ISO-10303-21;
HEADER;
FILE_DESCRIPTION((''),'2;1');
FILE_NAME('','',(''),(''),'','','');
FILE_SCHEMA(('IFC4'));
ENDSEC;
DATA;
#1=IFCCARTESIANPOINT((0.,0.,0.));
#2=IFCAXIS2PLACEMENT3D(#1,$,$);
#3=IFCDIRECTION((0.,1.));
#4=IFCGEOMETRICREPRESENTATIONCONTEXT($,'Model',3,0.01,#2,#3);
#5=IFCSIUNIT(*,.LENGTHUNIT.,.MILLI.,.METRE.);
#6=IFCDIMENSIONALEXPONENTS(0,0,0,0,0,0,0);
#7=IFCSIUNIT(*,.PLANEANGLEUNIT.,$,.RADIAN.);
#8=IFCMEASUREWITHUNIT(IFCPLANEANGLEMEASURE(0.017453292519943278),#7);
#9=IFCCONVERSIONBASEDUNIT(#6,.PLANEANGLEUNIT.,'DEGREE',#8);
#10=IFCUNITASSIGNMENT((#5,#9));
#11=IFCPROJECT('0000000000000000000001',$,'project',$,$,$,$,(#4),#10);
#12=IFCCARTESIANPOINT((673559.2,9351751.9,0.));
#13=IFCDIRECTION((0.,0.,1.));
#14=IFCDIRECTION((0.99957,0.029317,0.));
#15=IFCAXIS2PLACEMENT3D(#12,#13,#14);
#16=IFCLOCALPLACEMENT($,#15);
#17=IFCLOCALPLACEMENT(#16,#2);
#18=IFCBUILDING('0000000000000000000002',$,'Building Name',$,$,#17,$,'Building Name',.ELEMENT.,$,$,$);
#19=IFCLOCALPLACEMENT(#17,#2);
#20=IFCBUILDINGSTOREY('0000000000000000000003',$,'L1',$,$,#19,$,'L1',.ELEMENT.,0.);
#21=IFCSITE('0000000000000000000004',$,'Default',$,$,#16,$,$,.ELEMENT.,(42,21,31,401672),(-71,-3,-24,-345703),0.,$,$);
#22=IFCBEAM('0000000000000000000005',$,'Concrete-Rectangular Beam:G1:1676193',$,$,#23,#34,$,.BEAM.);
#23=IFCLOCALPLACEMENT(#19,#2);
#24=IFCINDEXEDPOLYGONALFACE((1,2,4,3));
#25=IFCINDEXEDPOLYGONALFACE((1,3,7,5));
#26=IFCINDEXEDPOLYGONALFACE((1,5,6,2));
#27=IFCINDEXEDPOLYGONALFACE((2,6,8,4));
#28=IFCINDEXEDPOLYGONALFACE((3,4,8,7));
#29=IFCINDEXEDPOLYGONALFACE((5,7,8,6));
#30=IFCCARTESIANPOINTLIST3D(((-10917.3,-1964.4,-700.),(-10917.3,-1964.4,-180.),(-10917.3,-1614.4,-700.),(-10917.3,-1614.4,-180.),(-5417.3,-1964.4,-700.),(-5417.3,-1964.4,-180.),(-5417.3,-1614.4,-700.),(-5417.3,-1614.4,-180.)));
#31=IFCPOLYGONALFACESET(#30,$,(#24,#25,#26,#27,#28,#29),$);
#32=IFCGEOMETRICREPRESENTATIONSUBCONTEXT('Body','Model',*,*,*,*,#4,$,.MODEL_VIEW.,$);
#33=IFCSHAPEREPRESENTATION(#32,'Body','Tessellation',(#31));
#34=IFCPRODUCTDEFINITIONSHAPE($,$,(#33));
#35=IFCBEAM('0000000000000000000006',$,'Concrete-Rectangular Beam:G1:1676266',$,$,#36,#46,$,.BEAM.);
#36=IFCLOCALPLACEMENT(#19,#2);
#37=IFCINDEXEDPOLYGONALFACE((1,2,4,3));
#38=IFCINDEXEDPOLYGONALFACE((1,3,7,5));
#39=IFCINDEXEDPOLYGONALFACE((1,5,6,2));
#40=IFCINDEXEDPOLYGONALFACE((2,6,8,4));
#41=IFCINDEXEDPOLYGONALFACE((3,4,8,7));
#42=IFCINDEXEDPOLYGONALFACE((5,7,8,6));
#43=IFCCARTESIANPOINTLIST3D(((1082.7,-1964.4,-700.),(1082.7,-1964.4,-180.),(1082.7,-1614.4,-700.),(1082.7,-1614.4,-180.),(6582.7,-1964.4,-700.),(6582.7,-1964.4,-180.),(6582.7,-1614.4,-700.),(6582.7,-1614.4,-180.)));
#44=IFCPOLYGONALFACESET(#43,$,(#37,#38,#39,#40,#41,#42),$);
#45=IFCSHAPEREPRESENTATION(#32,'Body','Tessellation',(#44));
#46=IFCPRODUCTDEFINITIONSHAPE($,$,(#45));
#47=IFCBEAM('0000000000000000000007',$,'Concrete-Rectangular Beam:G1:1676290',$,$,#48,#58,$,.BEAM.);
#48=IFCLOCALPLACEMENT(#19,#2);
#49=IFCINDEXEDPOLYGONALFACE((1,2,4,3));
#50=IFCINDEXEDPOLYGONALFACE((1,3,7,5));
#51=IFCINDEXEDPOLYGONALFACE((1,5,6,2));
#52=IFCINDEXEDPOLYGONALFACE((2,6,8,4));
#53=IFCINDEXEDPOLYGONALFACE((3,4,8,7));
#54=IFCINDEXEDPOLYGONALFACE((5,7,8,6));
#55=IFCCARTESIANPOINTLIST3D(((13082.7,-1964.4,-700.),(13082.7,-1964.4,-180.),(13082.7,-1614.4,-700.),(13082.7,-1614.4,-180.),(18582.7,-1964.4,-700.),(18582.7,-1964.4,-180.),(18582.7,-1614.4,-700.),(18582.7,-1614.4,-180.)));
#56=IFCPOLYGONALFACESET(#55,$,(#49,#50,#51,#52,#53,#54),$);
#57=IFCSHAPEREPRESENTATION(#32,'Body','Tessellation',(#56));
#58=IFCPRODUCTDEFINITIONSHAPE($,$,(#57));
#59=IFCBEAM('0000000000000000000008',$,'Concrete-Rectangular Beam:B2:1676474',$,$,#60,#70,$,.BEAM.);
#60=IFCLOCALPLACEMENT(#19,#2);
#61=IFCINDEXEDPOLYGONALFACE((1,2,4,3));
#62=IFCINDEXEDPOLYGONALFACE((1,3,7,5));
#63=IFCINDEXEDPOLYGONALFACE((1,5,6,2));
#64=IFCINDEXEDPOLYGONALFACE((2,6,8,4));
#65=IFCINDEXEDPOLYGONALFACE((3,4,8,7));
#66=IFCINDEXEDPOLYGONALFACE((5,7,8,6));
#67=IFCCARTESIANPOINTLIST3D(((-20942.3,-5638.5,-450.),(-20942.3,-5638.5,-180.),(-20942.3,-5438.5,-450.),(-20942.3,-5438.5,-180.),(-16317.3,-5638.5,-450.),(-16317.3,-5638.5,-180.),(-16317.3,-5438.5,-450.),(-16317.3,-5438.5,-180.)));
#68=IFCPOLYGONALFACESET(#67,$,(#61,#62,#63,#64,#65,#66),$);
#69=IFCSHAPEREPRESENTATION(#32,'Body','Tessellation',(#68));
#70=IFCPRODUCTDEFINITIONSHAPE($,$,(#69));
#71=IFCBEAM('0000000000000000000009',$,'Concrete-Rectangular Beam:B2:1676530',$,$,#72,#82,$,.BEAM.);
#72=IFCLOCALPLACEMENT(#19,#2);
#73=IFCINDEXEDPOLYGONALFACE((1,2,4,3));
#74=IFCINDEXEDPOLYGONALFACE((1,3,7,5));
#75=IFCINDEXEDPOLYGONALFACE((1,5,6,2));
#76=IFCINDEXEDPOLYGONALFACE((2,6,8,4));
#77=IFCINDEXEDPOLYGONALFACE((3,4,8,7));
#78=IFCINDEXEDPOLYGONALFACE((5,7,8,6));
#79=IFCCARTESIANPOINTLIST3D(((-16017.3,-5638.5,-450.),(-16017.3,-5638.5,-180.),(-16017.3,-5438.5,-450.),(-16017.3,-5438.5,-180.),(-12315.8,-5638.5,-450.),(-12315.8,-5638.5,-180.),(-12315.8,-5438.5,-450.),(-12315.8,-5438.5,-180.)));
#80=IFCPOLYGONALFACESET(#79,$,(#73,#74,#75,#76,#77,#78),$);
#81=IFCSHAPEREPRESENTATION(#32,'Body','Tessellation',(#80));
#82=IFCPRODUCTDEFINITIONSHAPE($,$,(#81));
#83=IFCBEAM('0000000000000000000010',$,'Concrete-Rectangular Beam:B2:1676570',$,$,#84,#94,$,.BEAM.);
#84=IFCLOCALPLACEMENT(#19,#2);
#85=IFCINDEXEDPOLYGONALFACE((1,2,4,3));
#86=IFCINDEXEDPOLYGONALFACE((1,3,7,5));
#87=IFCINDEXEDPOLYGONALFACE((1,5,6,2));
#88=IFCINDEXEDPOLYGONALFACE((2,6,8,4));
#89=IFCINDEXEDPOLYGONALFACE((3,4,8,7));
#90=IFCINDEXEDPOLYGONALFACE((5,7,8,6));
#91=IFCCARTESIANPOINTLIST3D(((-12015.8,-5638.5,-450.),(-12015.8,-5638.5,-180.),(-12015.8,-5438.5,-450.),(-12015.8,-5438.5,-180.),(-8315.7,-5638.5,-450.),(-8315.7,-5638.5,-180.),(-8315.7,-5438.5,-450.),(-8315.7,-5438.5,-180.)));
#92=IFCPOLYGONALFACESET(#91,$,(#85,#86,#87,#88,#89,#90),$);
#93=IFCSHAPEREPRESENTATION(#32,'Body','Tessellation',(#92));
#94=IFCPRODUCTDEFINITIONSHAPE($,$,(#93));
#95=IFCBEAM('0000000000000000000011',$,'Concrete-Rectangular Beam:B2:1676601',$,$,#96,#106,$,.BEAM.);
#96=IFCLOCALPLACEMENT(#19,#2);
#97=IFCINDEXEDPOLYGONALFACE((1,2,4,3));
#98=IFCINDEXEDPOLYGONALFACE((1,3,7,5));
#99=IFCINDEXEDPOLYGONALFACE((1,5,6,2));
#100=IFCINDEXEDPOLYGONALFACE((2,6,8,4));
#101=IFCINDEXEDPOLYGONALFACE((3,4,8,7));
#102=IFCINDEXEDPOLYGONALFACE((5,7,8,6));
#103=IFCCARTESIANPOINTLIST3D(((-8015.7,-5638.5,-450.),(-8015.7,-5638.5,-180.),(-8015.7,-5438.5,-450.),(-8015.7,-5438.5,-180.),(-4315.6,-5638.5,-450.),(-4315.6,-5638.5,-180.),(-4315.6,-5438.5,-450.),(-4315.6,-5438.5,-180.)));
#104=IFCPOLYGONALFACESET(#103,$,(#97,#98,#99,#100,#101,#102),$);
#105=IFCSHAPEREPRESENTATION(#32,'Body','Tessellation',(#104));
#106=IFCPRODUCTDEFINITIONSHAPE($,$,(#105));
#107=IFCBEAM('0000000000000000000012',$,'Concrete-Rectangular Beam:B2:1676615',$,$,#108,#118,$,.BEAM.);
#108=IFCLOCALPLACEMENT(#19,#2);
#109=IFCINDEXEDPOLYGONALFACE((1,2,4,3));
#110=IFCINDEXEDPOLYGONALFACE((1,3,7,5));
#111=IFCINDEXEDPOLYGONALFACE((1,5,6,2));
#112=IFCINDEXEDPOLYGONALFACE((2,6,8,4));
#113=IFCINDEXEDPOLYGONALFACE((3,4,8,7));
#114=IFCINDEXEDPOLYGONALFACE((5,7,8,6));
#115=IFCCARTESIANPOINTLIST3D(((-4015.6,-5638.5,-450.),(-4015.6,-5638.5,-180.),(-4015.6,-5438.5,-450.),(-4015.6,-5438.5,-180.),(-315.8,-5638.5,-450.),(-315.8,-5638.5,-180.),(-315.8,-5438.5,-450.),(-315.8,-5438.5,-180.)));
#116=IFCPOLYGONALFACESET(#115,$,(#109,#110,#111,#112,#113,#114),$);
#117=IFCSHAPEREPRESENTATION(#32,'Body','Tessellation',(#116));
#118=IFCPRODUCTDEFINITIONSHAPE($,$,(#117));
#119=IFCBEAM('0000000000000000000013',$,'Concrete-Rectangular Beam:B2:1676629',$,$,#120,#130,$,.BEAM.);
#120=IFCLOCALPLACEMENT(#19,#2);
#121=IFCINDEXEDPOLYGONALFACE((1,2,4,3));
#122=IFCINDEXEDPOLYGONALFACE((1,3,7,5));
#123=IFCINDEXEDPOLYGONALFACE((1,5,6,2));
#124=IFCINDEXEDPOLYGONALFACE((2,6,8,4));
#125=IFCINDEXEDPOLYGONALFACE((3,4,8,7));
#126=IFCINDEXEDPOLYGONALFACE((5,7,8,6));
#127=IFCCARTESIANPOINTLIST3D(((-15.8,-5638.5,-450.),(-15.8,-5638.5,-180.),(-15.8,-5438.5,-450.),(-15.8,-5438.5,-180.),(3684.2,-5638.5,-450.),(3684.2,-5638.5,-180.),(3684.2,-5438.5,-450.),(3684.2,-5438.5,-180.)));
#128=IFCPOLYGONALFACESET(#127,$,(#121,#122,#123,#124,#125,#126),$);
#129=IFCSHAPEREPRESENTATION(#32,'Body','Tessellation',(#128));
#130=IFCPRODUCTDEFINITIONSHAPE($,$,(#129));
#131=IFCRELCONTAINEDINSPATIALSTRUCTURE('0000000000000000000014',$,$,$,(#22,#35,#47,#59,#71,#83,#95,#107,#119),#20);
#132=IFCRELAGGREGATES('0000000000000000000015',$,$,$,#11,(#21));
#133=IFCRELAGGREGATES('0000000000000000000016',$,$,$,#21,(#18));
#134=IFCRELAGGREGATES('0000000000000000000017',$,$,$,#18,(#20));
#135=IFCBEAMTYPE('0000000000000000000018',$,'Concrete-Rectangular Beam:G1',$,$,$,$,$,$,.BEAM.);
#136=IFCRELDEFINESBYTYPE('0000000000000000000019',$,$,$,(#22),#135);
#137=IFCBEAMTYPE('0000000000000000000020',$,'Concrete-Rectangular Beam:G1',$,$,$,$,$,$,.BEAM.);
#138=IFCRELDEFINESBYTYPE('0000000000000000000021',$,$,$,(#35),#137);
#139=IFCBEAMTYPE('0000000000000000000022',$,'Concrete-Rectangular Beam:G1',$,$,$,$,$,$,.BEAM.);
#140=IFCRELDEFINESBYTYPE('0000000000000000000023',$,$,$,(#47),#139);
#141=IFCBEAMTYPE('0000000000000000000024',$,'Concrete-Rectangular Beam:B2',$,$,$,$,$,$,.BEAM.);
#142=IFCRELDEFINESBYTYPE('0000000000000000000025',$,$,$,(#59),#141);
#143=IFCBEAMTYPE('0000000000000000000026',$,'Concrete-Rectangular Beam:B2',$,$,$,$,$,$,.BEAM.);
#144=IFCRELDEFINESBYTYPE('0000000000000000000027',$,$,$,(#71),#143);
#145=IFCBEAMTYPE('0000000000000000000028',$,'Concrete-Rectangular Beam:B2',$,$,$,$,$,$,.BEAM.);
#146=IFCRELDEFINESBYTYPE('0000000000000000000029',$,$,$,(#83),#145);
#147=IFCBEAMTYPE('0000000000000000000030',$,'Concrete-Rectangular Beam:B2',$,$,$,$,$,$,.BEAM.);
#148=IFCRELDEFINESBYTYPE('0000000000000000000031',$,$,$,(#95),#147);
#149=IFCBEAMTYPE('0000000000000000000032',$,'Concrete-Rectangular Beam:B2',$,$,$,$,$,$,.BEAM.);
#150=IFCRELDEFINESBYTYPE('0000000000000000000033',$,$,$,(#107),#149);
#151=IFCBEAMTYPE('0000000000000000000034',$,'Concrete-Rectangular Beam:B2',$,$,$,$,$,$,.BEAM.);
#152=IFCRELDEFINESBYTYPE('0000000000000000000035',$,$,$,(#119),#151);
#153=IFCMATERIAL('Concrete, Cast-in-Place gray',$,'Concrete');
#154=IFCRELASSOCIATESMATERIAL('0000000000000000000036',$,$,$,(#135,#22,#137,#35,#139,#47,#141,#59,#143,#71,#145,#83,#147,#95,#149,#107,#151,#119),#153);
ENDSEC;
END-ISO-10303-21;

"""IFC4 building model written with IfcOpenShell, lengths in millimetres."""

from ifc_helpers import new_model, entity, si_unit, converted_unit, direction, frame, origin, place, context, subcontext, project, spatial, indexed_curve, outline, extrude, source, transform, mapped, material, type_object, type_shapes, element, save


model = new_model("IFC4")

# Units and contexts
model_context = context("Model", 3, precision=0.01, world=origin(), true_north=direction((0.0, 1.0)))
body_context = subcontext(model_context, "Body", "Model", "MODEL_VIEW")
ifc_project = project(units=[si_unit("LENGTHUNIT", "METRE", prefix="MILLI"), converted_unit("PLANEANGLEUNIT", "DEGREE", entity("IfcPlaneAngleMeasure", 0.017453292519943278), si_unit("PLANEANGLEUNIT", "RADIAN"), dimensions=[0, 0, 0, 0, 0, 0, 0])], contexts=[model_context])

# Site, building, storey
site_placement = place(None, frame((673559.2, 9351751.9, 0.0), z_axis=(0.0, 0.0, 1.0), x_axis=(0.99957, 0.029317, 0.0)))
site = spatial("IfcSite", under=ifc_project, at=site_placement, Name="Default", CompositionType="ELEMENT", RefLatitude=(42, 21, 31, 401672), RefLongitude=(-71, -3, -24, -345703), RefElevation=0.0)
building_placement = place(site_placement, origin())
building = spatial("IfcBuilding", under=site, at=building_placement, Name="Building Name", LongName="Building Name", CompositionType="ELEMENT")
storey_placement = place(building_placement, origin())
storey = spatial("IfcBuildingStorey", under=building, at=storey_placement, Name="L1", LongName="L1", CompositionType="ELEMENT", Elevation=0.0)

# Beams
ifc_material = material(Name="Concrete, Cast-in-Place gray", Category="Concrete")
beam_type_1 = type_object("IfcBeamType", Name="Concrete-Rectangular Beam:G1", PredefinedType="BEAM", material=ifc_material)
shared_shape_1 = source(origin(), body_context, "Body", "SweptSolid", [
    extrude(outline(indexed_curve([(-260.0, -175.0), (260.0, -175.0), (260.0, 175.0), (-260.0, 175.0), (-260.0, -175.0)], self_intersect=False)), frame((-10917.3, -1789.4, -440.0), z_axis=(1.0, 0.0, 0.0), x_axis=(0.0, 0.0, -1.0)), (0.0, 0.0, 1.0), 5500.0),
])
type_shapes(beam_type_1, [shared_shape_1])
beam_1_placement = place(storey_placement, origin())
element("IfcBeam", 1, at=beam_1_placement, inside=storey, type_object=beam_type_1, material=ifc_material, Name="Concrete-Rectangular Beam:G1:1676193", PredefinedType="BEAM", context=body_context, shape_type="MappedRepresentation", body=[
    mapped(shared_shape_1, transform((0.0, 0.0, 0.0), scale=1.0)),
])
beam_type_2 = type_object("IfcBeamType", Name="Concrete-Rectangular Beam:G1", PredefinedType="BEAM", material=ifc_material)
shared_shape_2 = source(origin(), body_context, "Body", "SweptSolid", [
    extrude(outline(indexed_curve([(-260.0, -175.0), (260.0, -175.0), (260.0, 175.0), (-260.0, 175.0), (-260.0, -175.0)], self_intersect=False)), frame((1082.7, -1789.4, -440.0), z_axis=(1.0, 0.0, 0.0), x_axis=(0.0, 0.0, -1.0)), (0.0, 0.0, 1.0), 5500.0),
])
type_shapes(beam_type_2, [shared_shape_2])
beam_2_placement = place(storey_placement, origin())
element("IfcBeam", 2, at=beam_2_placement, inside=storey, type_object=beam_type_2, material=ifc_material, Name="Concrete-Rectangular Beam:G1:1676266", PredefinedType="BEAM", context=body_context, shape_type="MappedRepresentation", body=[
    mapped(shared_shape_2, transform((0.0, 0.0, 0.0), scale=1.0)),
])
beam_type_3 = type_object("IfcBeamType", Name="Concrete-Rectangular Beam:G1", PredefinedType="BEAM", material=ifc_material)
shared_shape_3 = source(origin(), body_context, "Body", "SweptSolid", [
    extrude(outline(indexed_curve([(-260.0, -175.0), (260.0, -175.0), (260.0, 175.0), (-260.0, 175.0), (-260.0, -175.0)], self_intersect=False)), frame((13082.7, -1789.4, -440.0), z_axis=(1.0, 0.0, 0.0), x_axis=(0.0, 0.0, -1.0)), (0.0, 0.0, 1.0), 5500.0),
])
type_shapes(beam_type_3, [shared_shape_3])
beam_3_placement = place(storey_placement, origin())
element("IfcBeam", 3, at=beam_3_placement, inside=storey, type_object=beam_type_3, material=ifc_material, Name="Concrete-Rectangular Beam:G1:1676290", PredefinedType="BEAM", context=body_context, shape_type="MappedRepresentation", body=[
    mapped(shared_shape_3, transform((0.0, 0.0, 0.0), scale=1.0)),
])
beam_type_4 = type_object("IfcBeamType", Name="Concrete-Rectangular Beam:B2", PredefinedType="BEAM", material=ifc_material)
shared_shape_4 = source(origin(), body_context, "Body", "SweptSolid", [
    extrude(outline(indexed_curve([(-135.0, -100.0), (135.0, -100.0), (135.0, 100.0), (-135.0, 100.0), (-135.0, -100.0)], self_intersect=False)), frame((-20942.3, -5538.5, -315.0), z_axis=(1.0, 0.0, 0.0), x_axis=(0.0, 0.0, -1.0)), (0.0, 0.0, 1.0), 4625.0),
])
type_shapes(beam_type_4, [shared_shape_4])
beam_4_placement = place(storey_placement, origin())
element("IfcBeam", 4, at=beam_4_placement, inside=storey, type_object=beam_type_4, material=ifc_material, Name="Concrete-Rectangular Beam:B2:1676474", PredefinedType="BEAM", context=body_context, shape_type="MappedRepresentation", body=[
    mapped(shared_shape_4, transform((0.0, 0.0, 0.0), scale=1.0)),
])
beam_type_5 = type_object("IfcBeamType", Name="Concrete-Rectangular Beam:B2", PredefinedType="BEAM", material=ifc_material)
shared_shape_5 = source(origin(), body_context, "Body", "SweptSolid", [
    extrude(outline(indexed_curve([(-135.0, -100.0), (135.0, -100.0), (135.0, 100.0), (-135.0, 100.0), (-135.0, -100.0)], self_intersect=False)), frame((-16017.3, -5538.5, -315.0), z_axis=(1.0, 0.0, 0.0), x_axis=(0.0, 0.0, -1.0)), (0.0, 0.0, 1.0), 3701.5),
])
type_shapes(beam_type_5, [shared_shape_5])
beam_5_placement = place(storey_placement, origin())
element("IfcBeam", 5, at=beam_5_placement, inside=storey, type_object=beam_type_5, material=ifc_material, Name="Concrete-Rectangular Beam:B2:1676530", PredefinedType="BEAM", context=body_context, shape_type="MappedRepresentation", body=[
    mapped(shared_shape_5, transform((0.0, 0.0, 0.0), scale=1.0)),
])
beam_type_6 = type_object("IfcBeamType", Name="Concrete-Rectangular Beam:B2", PredefinedType="BEAM", material=ifc_material)
shared_shape_6 = source(origin(), body_context, "Body", "SweptSolid", [
    extrude(outline(indexed_curve([(-135.0, -100.0), (135.0, -100.0), (135.0, 100.0), (-135.0, 100.0), (-135.0, -100.0)], self_intersect=False)), frame((-8315.7, -5538.5, -315.0), z_axis=(-1.0, 0.0, 0.0), x_axis=(0.0, 0.0, -1.0)), (0.0, 0.0, 1.0), 3700.1),
])
type_shapes(beam_type_6, [shared_shape_6])
beam_6_placement = place(storey_placement, origin())
element("IfcBeam", 6, at=beam_6_placement, inside=storey, type_object=beam_type_6, material=ifc_material, Name="Concrete-Rectangular Beam:B2:1676570", PredefinedType="BEAM", context=body_context, shape_type="MappedRepresentation", body=[
    mapped(shared_shape_6, transform((0.0, 0.0, 0.0), scale=1.0)),
])
beam_type_7 = type_object("IfcBeamType", Name="Concrete-Rectangular Beam:B2", PredefinedType="BEAM", material=ifc_material)
shared_shape_7 = source(origin(), body_context, "Body", "SweptSolid", [
    extrude(outline(indexed_curve([(-135.0, -100.0), (135.0, -100.0), (135.0, 100.0), (-135.0, 100.0), (-135.0, -100.0)], self_intersect=False)), frame((-8015.7, -5538.5, -315.0), z_axis=(1.0, 0.0, 0.0), x_axis=(0.0, 0.0, -1.0)), (0.0, 0.0, 1.0), 3700.1),
])
type_shapes(beam_type_7, [shared_shape_7])
beam_7_placement = place(storey_placement, origin())
element("IfcBeam", 7, at=beam_7_placement, inside=storey, type_object=beam_type_7, material=ifc_material, Name="Concrete-Rectangular Beam:B2:1676601", PredefinedType="BEAM", context=body_context, shape_type="MappedRepresentation", body=[
    mapped(shared_shape_7, transform((0.0, 0.0, 0.0), scale=1.0)),
])
beam_type_8 = type_object("IfcBeamType", Name="Concrete-Rectangular Beam:B2", PredefinedType="BEAM", material=ifc_material)
shared_shape_8 = source(origin(), body_context, "Body", "SweptSolid", [
    extrude(outline(indexed_curve([(-135.0, -100.0), (135.0, -100.0), (135.0, 100.0), (-135.0, 100.0), (-135.0, -100.0)], self_intersect=False)), frame((-4015.6, -5538.5, -315.0), z_axis=(1.0, 0.0, 0.0), x_axis=(0.0, 0.0, -1.0)), (0.0, 0.0, 1.0), 3699.7),
])
type_shapes(beam_type_8, [shared_shape_8])
beam_8_placement = place(storey_placement, origin())
element("IfcBeam", 8, at=beam_8_placement, inside=storey, type_object=beam_type_8, material=ifc_material, Name="Concrete-Rectangular Beam:B2:1676615", PredefinedType="BEAM", context=body_context, shape_type="MappedRepresentation", body=[
    mapped(shared_shape_8, transform((0.0, 0.0, 0.0), scale=1.0)),
])
beam_type_9 = type_object("IfcBeamType", Name="Concrete-Rectangular Beam:B2", PredefinedType="BEAM", material=ifc_material)
shared_shape_9 = source(origin(), body_context, "Body", "SweptSolid", [
    extrude(outline(indexed_curve([(-135.0, -100.0), (135.0, -100.0), (135.0, 100.0), (-135.0, 100.0), (-135.0, -100.0)], self_intersect=False)), frame((-15.8, -5538.5, -315.0), z_axis=(1.0, 0.0, 0.0), x_axis=(0.0, 0.0, -1.0)), (0.0, 0.0, 1.0), 3700.0),
])
type_shapes(beam_type_9, [shared_shape_9])
beam_9_placement = place(storey_placement, origin())
element("IfcBeam", 9, at=beam_9_placement, inside=storey, type_object=beam_type_9, material=ifc_material, Name="Concrete-Rectangular Beam:B2:1676629", PredefinedType="BEAM", context=body_context, shape_type="MappedRepresentation", body=[
    mapped(shared_shape_9, transform((0.0, 0.0, 0.0), scale=1.0)),
])

save(model, "model.ifc")
